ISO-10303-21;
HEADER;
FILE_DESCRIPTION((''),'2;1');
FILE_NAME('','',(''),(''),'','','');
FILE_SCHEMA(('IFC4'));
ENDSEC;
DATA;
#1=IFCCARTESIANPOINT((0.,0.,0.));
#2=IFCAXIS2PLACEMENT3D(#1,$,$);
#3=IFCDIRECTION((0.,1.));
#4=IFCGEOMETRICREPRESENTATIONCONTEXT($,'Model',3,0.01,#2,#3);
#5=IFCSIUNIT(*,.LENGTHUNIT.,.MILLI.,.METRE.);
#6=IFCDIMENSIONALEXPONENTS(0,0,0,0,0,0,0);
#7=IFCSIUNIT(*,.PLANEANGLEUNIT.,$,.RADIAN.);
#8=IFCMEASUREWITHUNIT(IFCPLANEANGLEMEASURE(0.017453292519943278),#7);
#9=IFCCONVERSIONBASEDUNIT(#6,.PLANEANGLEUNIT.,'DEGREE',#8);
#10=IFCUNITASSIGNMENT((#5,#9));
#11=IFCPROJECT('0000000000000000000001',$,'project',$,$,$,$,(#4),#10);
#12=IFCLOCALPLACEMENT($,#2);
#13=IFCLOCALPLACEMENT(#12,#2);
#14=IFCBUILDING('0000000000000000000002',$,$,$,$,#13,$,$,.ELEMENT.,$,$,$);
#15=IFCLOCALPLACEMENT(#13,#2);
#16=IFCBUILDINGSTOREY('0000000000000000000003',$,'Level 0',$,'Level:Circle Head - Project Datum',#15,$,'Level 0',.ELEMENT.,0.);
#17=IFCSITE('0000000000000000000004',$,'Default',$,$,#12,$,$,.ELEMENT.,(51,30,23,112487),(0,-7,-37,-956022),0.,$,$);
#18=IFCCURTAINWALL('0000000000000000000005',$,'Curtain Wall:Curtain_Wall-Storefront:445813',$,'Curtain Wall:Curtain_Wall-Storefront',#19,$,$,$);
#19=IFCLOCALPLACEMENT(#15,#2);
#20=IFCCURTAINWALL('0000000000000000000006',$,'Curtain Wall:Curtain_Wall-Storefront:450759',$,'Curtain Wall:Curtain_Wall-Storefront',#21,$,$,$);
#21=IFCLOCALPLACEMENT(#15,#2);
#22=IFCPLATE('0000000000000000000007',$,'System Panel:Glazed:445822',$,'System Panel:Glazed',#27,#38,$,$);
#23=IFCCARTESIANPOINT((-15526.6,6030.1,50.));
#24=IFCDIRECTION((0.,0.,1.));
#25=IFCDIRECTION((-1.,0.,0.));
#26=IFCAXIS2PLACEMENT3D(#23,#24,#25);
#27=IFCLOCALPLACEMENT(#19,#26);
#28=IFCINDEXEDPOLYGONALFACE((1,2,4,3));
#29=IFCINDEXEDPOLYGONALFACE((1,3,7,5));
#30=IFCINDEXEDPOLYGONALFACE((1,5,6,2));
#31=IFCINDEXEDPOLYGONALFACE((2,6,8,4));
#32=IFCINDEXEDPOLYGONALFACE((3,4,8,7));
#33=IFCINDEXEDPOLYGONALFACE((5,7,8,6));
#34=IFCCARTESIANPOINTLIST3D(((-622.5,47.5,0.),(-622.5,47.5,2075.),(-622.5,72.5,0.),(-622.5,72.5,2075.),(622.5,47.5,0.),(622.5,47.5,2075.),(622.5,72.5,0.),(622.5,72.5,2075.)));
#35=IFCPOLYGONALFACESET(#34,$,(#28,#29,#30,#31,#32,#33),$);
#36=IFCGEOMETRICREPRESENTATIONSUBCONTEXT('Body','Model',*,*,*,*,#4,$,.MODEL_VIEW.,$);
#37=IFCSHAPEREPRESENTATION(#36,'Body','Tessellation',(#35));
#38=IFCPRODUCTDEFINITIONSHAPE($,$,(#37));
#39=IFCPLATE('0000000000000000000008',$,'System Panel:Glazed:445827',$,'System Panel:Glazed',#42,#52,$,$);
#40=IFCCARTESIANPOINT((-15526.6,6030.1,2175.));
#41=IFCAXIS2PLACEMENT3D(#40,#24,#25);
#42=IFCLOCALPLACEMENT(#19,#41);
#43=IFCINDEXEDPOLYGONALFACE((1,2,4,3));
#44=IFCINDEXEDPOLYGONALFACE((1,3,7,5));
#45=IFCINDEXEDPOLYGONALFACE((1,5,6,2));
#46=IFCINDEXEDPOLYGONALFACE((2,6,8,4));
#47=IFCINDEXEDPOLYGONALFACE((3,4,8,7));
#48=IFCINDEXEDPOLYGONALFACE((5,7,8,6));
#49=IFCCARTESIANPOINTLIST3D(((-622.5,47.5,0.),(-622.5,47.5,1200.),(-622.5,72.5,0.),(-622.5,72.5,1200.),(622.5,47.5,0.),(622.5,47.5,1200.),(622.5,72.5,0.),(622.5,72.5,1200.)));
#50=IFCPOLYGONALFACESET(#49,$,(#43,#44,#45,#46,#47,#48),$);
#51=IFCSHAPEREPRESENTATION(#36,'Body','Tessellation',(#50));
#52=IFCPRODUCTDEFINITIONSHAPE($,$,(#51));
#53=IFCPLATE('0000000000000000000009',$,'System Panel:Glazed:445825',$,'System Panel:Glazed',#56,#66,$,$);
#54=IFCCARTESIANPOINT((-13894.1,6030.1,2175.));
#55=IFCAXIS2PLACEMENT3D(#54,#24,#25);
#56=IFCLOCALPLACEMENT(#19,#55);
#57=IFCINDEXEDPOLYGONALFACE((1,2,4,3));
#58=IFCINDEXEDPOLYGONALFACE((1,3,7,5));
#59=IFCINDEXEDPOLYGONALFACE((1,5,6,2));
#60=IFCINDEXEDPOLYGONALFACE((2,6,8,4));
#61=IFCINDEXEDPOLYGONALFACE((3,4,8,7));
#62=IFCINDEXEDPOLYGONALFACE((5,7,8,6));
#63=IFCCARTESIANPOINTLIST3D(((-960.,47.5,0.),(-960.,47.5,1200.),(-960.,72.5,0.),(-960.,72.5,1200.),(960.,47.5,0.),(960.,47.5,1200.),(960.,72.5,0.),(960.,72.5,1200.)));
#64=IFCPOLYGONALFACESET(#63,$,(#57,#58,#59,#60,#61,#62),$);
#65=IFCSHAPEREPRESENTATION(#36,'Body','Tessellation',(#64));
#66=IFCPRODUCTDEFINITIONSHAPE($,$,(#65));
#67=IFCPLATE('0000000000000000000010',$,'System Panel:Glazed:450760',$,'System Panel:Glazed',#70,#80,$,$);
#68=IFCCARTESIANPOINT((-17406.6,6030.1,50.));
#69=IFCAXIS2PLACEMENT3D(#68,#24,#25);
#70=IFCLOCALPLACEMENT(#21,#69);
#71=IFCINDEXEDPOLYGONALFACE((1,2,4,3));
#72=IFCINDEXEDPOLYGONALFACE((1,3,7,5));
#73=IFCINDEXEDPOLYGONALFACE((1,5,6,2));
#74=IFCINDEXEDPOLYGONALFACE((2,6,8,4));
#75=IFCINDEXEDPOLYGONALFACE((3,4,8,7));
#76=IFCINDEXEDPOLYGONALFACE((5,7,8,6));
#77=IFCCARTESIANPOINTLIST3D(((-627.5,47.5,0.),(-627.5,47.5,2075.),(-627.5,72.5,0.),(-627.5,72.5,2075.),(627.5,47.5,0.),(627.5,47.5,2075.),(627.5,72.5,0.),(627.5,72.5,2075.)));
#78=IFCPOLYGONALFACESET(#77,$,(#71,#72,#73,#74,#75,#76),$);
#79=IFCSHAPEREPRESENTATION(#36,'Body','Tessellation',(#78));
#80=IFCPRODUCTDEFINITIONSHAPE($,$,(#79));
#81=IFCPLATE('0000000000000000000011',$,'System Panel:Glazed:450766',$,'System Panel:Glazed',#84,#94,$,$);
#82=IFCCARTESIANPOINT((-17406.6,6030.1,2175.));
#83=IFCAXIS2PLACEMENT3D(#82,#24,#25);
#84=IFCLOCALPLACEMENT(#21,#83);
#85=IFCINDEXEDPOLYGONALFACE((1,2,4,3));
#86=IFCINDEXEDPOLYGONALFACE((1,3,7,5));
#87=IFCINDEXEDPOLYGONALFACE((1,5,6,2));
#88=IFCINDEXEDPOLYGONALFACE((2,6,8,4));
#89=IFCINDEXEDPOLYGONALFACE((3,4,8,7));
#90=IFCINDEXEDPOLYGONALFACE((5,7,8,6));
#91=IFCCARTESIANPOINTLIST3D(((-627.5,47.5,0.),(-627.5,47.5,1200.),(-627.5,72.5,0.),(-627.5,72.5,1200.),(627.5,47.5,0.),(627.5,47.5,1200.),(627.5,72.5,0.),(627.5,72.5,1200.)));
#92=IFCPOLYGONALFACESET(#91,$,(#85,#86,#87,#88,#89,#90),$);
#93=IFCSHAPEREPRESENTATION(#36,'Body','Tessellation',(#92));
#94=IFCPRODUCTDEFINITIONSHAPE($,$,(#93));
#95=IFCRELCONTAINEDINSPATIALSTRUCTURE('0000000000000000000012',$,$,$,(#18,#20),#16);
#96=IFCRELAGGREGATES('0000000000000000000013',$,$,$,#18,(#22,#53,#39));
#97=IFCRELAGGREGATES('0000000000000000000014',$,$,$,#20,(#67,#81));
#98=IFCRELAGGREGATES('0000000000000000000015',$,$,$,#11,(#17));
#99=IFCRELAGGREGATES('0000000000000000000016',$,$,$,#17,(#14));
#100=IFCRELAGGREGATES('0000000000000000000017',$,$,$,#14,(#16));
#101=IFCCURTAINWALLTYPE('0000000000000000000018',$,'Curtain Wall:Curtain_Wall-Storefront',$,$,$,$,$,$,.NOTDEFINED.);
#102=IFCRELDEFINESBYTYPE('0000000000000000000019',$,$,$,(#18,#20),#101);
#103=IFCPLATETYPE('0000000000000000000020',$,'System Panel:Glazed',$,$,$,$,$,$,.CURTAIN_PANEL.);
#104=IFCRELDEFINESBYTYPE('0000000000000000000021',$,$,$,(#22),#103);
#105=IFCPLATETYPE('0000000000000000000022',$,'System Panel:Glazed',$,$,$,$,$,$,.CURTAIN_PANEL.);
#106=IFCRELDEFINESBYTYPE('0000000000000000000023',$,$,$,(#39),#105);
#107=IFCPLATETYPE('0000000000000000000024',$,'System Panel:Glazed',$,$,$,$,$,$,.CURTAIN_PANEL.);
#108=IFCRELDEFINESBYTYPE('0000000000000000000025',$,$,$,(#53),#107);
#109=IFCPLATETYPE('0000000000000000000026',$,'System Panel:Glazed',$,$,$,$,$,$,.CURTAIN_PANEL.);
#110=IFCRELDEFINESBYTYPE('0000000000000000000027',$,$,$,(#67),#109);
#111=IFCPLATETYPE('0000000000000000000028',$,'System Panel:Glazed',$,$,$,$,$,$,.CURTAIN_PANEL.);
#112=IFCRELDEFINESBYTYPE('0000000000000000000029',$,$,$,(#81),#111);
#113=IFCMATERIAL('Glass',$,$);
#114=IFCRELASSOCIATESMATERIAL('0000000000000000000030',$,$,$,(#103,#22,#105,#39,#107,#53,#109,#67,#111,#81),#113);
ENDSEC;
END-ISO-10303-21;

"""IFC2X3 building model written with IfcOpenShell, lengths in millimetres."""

from ifc_helpers import new_model, entity, si_unit, converted_unit, direction, frame, origin, origin_2d_with_axis, place, context, subcontext, project, spatial, rectangle, extrude, source, transform, mapped, material, type_object, type_shapes, element, aggregate, save


model = new_model("IFC2X3")

# Units and contexts
model_context = context("Model", 3, precision=0.01, world=origin(), true_north=direction((0.0, 1.0)))
body_context = subcontext(model_context, "Body", "Model", "MODEL_VIEW")
ifc_project = project(units=[si_unit("LENGTHUNIT", "METRE", prefix="MILLI"), converted_unit("PLANEANGLEUNIT", "DEGREE", entity("IfcPlaneAngleMeasure", 0.017453292519943278), si_unit("PLANEANGLEUNIT", "RADIAN"), dimensions=[0, 0, 0, 0, 0, 0, 0])], contexts=[model_context])

# Site, building, storey
site_placement = place(None, origin())
site = spatial("IfcSite", under=ifc_project, at=site_placement, Name="Default", CompositionType="ELEMENT", RefLatitude=(51, 30, 23, 112487), RefLongitude=(0, -7, -37, -956022), RefElevation=0.0)
building_placement = place(site_placement, origin())
building = spatial("IfcBuilding", under=site, at=building_placement, CompositionType="ELEMENT")
storey_placement = place(building_placement, origin())
storey = spatial("IfcBuildingStorey", under=building, at=storey_placement, Name="Level 0", ObjectType="Level:Circle Head - Project Datum", LongName="Level 0", CompositionType="ELEMENT", Elevation=0.0)

# Curtain walls
curtain_wall_type = type_object("IfcCurtainWallType", Name="Curtain Wall:Curtain_Wall-Storefront", PredefinedType="NOTDEFINED")
curtain_wall_1_placement = place(storey_placement, origin())
curtain_wall_1 = element("IfcCurtainWall", 1, at=curtain_wall_1_placement, inside=storey, type_object=curtain_wall_type, Name="Curtain Wall:Curtain_Wall-Storefront:445813", ObjectType="Curtain Wall:Curtain_Wall-Storefront")
curtain_wall_2_placement = place(storey_placement, origin())
curtain_wall_2 = element("IfcCurtainWall", 2, at=curtain_wall_2_placement, inside=storey, type_object=curtain_wall_type, Name="Curtain Wall:Curtain_Wall-Storefront:450759", ObjectType="Curtain Wall:Curtain_Wall-Storefront")

# Plates
ifc_material_1 = material(Name="Glass")
plate_type_1 = type_object("IfcPlateType", Name="System Panel:Glazed", PredefinedType="CURTAIN_PANEL", material=ifc_material_1)
shared_shape_1 = source(origin(), body_context, "Body", "SweptSolid", [
    extrude(rectangle(XDim=25.0, YDim=1245.0, at=origin_2d_with_axis()), frame((0.0, 60.0, 0.0), z_axis=(0.0, 0.0, 1.0), x_axis=(0.0, 1.0, 0.0)), (0.0, 0.0, 1.0), 2075.0),
])
type_shapes(plate_type_1, [shared_shape_1])
plate_1_placement = place(curtain_wall_1_placement, frame((-15526.6, 6030.1, 50.0), z_axis=(0.0, 0.0, 1.0), x_axis=(-1.0, 0.0, 0.0)))
plate_1 = element("IfcPlate", 3, at=plate_1_placement, type_object=plate_type_1, material=ifc_material_1, Name="System Panel:Glazed:445822", ObjectType="System Panel:Glazed", context=body_context, shape_type="MappedRepresentation", body=[
    mapped(shared_shape_1, transform((0.0, 0.0, 0.0), scale=1.0)),
])
plate_type_2 = type_object("IfcPlateType", Name="System Panel:Glazed", PredefinedType="CURTAIN_PANEL", material=ifc_material_1)
shared_shape_2 = source(origin(), body_context, "Body", "SweptSolid", [
    extrude(rectangle(XDim=25.0, YDim=1245.0, at=origin_2d_with_axis()), frame((0.0, 60.0, 0.0), z_axis=(0.0, 0.0, 1.0), x_axis=(0.0, 1.0, 0.0)), (0.0, 0.0, 1.0), 1200.0),
])
type_shapes(plate_type_2, [shared_shape_2])
plate_2_placement = place(curtain_wall_1_placement, frame((-15526.6, 6030.1, 2175.0), z_axis=(0.0, 0.0, 1.0), x_axis=(-1.0, 0.0, 0.0)))
plate_2 = element("IfcPlate", 4, at=plate_2_placement, type_object=plate_type_2, material=ifc_material_1, Name="System Panel:Glazed:445827", ObjectType="System Panel:Glazed", context=body_context, shape_type="MappedRepresentation", body=[
    mapped(shared_shape_2, transform((0.0, 0.0, 0.0), scale=1.0)),
])
plate_type_3 = type_object("IfcPlateType", Name="System Panel:Glazed", PredefinedType="CURTAIN_PANEL", material=ifc_material_1)
shared_shape_3 = source(origin(), body_context, "Body", "SweptSolid", [
    extrude(rectangle(XDim=25.0, YDim=1920.0, at=origin_2d_with_axis()), frame((0.0, 60.0, 0.0), z_axis=(0.0, 0.0, 1.0), x_axis=(0.0, 1.0, 0.0)), (0.0, 0.0, 1.0), 1200.0),
])
type_shapes(plate_type_3, [shared_shape_3])
plate_3_placement = place(curtain_wall_1_placement, frame((-13894.1, 6030.1, 2175.0), z_axis=(0.0, 0.0, 1.0), x_axis=(-1.0, 0.0, 0.0)))
plate_3 = element("IfcPlate", 5, at=plate_3_placement, type_object=plate_type_3, material=ifc_material_1, Name="System Panel:Glazed:445825", ObjectType="System Panel:Glazed", context=body_context, shape_type="MappedRepresentation", body=[
    mapped(shared_shape_3, transform((0.0, 0.0, 0.0), scale=1.0)),
])
aggregate(curtain_wall_1, [plate_1, plate_3, plate_2])
plate_type_4 = type_object("IfcPlateType", Name="System Panel:Glazed", PredefinedType="CURTAIN_PANEL", material=ifc_material_1)
shared_shape_4 = source(origin(), body_context, "Body", "SweptSolid", [
    extrude(rectangle(XDim=25.0, YDim=1255.0, at=origin_2d_with_axis()), frame((0.0, 60.0, 0.0), z_axis=(0.0, 0.0, 1.0), x_axis=(0.0, 1.0, 0.0)), (0.0, 0.0, 1.0), 2075.0),
])
type_shapes(plate_type_4, [shared_shape_4])
plate_4_placement = place(curtain_wall_2_placement, frame((-17406.6, 6030.1, 50.0), z_axis=(0.0, 0.0, 1.0), x_axis=(-1.0, 0.0, 0.0)))
plate_4 = element("IfcPlate", 6, at=plate_4_placement, type_object=plate_type_4, material=ifc_material_1, Name="System Panel:Glazed:450760", ObjectType="System Panel:Glazed", context=body_context, shape_type="MappedRepresentation", body=[
    mapped(shared_shape_4, transform((0.0, 0.0, 0.0), scale=1.0)),
])
plate_type_5 = type_object("IfcPlateType", Name="System Panel:Glazed", PredefinedType="CURTAIN_PANEL", material=ifc_material_1)
shared_shape_5 = source(origin(), body_context, "Body", "SweptSolid", [
    extrude(rectangle(XDim=25.0, YDim=1255.0, at=origin_2d_with_axis()), frame((0.0, 60.0, 0.0), z_axis=(0.0, 0.0, 1.0), x_axis=(0.0, 1.0, 0.0)), (0.0, 0.0, 1.0), 1200.0),
])
type_shapes(plate_type_5, [shared_shape_5])
plate_5_placement = place(curtain_wall_2_placement, frame((-17406.6, 6030.1, 2175.0), z_axis=(0.0, 0.0, 1.0), x_axis=(-1.0, 0.0, 0.0)))
plate_5 = element("IfcPlate", 7, at=plate_5_placement, type_object=plate_type_5, material=ifc_material_1, Name="System Panel:Glazed:450766", ObjectType="System Panel:Glazed", context=body_context, shape_type="MappedRepresentation", body=[
    mapped(shared_shape_5, transform((0.0, 0.0, 0.0), scale=1.0)),
])
aggregate(curtain_wall_2, [plate_4, plate_5])

save(model, "model.ifc")
